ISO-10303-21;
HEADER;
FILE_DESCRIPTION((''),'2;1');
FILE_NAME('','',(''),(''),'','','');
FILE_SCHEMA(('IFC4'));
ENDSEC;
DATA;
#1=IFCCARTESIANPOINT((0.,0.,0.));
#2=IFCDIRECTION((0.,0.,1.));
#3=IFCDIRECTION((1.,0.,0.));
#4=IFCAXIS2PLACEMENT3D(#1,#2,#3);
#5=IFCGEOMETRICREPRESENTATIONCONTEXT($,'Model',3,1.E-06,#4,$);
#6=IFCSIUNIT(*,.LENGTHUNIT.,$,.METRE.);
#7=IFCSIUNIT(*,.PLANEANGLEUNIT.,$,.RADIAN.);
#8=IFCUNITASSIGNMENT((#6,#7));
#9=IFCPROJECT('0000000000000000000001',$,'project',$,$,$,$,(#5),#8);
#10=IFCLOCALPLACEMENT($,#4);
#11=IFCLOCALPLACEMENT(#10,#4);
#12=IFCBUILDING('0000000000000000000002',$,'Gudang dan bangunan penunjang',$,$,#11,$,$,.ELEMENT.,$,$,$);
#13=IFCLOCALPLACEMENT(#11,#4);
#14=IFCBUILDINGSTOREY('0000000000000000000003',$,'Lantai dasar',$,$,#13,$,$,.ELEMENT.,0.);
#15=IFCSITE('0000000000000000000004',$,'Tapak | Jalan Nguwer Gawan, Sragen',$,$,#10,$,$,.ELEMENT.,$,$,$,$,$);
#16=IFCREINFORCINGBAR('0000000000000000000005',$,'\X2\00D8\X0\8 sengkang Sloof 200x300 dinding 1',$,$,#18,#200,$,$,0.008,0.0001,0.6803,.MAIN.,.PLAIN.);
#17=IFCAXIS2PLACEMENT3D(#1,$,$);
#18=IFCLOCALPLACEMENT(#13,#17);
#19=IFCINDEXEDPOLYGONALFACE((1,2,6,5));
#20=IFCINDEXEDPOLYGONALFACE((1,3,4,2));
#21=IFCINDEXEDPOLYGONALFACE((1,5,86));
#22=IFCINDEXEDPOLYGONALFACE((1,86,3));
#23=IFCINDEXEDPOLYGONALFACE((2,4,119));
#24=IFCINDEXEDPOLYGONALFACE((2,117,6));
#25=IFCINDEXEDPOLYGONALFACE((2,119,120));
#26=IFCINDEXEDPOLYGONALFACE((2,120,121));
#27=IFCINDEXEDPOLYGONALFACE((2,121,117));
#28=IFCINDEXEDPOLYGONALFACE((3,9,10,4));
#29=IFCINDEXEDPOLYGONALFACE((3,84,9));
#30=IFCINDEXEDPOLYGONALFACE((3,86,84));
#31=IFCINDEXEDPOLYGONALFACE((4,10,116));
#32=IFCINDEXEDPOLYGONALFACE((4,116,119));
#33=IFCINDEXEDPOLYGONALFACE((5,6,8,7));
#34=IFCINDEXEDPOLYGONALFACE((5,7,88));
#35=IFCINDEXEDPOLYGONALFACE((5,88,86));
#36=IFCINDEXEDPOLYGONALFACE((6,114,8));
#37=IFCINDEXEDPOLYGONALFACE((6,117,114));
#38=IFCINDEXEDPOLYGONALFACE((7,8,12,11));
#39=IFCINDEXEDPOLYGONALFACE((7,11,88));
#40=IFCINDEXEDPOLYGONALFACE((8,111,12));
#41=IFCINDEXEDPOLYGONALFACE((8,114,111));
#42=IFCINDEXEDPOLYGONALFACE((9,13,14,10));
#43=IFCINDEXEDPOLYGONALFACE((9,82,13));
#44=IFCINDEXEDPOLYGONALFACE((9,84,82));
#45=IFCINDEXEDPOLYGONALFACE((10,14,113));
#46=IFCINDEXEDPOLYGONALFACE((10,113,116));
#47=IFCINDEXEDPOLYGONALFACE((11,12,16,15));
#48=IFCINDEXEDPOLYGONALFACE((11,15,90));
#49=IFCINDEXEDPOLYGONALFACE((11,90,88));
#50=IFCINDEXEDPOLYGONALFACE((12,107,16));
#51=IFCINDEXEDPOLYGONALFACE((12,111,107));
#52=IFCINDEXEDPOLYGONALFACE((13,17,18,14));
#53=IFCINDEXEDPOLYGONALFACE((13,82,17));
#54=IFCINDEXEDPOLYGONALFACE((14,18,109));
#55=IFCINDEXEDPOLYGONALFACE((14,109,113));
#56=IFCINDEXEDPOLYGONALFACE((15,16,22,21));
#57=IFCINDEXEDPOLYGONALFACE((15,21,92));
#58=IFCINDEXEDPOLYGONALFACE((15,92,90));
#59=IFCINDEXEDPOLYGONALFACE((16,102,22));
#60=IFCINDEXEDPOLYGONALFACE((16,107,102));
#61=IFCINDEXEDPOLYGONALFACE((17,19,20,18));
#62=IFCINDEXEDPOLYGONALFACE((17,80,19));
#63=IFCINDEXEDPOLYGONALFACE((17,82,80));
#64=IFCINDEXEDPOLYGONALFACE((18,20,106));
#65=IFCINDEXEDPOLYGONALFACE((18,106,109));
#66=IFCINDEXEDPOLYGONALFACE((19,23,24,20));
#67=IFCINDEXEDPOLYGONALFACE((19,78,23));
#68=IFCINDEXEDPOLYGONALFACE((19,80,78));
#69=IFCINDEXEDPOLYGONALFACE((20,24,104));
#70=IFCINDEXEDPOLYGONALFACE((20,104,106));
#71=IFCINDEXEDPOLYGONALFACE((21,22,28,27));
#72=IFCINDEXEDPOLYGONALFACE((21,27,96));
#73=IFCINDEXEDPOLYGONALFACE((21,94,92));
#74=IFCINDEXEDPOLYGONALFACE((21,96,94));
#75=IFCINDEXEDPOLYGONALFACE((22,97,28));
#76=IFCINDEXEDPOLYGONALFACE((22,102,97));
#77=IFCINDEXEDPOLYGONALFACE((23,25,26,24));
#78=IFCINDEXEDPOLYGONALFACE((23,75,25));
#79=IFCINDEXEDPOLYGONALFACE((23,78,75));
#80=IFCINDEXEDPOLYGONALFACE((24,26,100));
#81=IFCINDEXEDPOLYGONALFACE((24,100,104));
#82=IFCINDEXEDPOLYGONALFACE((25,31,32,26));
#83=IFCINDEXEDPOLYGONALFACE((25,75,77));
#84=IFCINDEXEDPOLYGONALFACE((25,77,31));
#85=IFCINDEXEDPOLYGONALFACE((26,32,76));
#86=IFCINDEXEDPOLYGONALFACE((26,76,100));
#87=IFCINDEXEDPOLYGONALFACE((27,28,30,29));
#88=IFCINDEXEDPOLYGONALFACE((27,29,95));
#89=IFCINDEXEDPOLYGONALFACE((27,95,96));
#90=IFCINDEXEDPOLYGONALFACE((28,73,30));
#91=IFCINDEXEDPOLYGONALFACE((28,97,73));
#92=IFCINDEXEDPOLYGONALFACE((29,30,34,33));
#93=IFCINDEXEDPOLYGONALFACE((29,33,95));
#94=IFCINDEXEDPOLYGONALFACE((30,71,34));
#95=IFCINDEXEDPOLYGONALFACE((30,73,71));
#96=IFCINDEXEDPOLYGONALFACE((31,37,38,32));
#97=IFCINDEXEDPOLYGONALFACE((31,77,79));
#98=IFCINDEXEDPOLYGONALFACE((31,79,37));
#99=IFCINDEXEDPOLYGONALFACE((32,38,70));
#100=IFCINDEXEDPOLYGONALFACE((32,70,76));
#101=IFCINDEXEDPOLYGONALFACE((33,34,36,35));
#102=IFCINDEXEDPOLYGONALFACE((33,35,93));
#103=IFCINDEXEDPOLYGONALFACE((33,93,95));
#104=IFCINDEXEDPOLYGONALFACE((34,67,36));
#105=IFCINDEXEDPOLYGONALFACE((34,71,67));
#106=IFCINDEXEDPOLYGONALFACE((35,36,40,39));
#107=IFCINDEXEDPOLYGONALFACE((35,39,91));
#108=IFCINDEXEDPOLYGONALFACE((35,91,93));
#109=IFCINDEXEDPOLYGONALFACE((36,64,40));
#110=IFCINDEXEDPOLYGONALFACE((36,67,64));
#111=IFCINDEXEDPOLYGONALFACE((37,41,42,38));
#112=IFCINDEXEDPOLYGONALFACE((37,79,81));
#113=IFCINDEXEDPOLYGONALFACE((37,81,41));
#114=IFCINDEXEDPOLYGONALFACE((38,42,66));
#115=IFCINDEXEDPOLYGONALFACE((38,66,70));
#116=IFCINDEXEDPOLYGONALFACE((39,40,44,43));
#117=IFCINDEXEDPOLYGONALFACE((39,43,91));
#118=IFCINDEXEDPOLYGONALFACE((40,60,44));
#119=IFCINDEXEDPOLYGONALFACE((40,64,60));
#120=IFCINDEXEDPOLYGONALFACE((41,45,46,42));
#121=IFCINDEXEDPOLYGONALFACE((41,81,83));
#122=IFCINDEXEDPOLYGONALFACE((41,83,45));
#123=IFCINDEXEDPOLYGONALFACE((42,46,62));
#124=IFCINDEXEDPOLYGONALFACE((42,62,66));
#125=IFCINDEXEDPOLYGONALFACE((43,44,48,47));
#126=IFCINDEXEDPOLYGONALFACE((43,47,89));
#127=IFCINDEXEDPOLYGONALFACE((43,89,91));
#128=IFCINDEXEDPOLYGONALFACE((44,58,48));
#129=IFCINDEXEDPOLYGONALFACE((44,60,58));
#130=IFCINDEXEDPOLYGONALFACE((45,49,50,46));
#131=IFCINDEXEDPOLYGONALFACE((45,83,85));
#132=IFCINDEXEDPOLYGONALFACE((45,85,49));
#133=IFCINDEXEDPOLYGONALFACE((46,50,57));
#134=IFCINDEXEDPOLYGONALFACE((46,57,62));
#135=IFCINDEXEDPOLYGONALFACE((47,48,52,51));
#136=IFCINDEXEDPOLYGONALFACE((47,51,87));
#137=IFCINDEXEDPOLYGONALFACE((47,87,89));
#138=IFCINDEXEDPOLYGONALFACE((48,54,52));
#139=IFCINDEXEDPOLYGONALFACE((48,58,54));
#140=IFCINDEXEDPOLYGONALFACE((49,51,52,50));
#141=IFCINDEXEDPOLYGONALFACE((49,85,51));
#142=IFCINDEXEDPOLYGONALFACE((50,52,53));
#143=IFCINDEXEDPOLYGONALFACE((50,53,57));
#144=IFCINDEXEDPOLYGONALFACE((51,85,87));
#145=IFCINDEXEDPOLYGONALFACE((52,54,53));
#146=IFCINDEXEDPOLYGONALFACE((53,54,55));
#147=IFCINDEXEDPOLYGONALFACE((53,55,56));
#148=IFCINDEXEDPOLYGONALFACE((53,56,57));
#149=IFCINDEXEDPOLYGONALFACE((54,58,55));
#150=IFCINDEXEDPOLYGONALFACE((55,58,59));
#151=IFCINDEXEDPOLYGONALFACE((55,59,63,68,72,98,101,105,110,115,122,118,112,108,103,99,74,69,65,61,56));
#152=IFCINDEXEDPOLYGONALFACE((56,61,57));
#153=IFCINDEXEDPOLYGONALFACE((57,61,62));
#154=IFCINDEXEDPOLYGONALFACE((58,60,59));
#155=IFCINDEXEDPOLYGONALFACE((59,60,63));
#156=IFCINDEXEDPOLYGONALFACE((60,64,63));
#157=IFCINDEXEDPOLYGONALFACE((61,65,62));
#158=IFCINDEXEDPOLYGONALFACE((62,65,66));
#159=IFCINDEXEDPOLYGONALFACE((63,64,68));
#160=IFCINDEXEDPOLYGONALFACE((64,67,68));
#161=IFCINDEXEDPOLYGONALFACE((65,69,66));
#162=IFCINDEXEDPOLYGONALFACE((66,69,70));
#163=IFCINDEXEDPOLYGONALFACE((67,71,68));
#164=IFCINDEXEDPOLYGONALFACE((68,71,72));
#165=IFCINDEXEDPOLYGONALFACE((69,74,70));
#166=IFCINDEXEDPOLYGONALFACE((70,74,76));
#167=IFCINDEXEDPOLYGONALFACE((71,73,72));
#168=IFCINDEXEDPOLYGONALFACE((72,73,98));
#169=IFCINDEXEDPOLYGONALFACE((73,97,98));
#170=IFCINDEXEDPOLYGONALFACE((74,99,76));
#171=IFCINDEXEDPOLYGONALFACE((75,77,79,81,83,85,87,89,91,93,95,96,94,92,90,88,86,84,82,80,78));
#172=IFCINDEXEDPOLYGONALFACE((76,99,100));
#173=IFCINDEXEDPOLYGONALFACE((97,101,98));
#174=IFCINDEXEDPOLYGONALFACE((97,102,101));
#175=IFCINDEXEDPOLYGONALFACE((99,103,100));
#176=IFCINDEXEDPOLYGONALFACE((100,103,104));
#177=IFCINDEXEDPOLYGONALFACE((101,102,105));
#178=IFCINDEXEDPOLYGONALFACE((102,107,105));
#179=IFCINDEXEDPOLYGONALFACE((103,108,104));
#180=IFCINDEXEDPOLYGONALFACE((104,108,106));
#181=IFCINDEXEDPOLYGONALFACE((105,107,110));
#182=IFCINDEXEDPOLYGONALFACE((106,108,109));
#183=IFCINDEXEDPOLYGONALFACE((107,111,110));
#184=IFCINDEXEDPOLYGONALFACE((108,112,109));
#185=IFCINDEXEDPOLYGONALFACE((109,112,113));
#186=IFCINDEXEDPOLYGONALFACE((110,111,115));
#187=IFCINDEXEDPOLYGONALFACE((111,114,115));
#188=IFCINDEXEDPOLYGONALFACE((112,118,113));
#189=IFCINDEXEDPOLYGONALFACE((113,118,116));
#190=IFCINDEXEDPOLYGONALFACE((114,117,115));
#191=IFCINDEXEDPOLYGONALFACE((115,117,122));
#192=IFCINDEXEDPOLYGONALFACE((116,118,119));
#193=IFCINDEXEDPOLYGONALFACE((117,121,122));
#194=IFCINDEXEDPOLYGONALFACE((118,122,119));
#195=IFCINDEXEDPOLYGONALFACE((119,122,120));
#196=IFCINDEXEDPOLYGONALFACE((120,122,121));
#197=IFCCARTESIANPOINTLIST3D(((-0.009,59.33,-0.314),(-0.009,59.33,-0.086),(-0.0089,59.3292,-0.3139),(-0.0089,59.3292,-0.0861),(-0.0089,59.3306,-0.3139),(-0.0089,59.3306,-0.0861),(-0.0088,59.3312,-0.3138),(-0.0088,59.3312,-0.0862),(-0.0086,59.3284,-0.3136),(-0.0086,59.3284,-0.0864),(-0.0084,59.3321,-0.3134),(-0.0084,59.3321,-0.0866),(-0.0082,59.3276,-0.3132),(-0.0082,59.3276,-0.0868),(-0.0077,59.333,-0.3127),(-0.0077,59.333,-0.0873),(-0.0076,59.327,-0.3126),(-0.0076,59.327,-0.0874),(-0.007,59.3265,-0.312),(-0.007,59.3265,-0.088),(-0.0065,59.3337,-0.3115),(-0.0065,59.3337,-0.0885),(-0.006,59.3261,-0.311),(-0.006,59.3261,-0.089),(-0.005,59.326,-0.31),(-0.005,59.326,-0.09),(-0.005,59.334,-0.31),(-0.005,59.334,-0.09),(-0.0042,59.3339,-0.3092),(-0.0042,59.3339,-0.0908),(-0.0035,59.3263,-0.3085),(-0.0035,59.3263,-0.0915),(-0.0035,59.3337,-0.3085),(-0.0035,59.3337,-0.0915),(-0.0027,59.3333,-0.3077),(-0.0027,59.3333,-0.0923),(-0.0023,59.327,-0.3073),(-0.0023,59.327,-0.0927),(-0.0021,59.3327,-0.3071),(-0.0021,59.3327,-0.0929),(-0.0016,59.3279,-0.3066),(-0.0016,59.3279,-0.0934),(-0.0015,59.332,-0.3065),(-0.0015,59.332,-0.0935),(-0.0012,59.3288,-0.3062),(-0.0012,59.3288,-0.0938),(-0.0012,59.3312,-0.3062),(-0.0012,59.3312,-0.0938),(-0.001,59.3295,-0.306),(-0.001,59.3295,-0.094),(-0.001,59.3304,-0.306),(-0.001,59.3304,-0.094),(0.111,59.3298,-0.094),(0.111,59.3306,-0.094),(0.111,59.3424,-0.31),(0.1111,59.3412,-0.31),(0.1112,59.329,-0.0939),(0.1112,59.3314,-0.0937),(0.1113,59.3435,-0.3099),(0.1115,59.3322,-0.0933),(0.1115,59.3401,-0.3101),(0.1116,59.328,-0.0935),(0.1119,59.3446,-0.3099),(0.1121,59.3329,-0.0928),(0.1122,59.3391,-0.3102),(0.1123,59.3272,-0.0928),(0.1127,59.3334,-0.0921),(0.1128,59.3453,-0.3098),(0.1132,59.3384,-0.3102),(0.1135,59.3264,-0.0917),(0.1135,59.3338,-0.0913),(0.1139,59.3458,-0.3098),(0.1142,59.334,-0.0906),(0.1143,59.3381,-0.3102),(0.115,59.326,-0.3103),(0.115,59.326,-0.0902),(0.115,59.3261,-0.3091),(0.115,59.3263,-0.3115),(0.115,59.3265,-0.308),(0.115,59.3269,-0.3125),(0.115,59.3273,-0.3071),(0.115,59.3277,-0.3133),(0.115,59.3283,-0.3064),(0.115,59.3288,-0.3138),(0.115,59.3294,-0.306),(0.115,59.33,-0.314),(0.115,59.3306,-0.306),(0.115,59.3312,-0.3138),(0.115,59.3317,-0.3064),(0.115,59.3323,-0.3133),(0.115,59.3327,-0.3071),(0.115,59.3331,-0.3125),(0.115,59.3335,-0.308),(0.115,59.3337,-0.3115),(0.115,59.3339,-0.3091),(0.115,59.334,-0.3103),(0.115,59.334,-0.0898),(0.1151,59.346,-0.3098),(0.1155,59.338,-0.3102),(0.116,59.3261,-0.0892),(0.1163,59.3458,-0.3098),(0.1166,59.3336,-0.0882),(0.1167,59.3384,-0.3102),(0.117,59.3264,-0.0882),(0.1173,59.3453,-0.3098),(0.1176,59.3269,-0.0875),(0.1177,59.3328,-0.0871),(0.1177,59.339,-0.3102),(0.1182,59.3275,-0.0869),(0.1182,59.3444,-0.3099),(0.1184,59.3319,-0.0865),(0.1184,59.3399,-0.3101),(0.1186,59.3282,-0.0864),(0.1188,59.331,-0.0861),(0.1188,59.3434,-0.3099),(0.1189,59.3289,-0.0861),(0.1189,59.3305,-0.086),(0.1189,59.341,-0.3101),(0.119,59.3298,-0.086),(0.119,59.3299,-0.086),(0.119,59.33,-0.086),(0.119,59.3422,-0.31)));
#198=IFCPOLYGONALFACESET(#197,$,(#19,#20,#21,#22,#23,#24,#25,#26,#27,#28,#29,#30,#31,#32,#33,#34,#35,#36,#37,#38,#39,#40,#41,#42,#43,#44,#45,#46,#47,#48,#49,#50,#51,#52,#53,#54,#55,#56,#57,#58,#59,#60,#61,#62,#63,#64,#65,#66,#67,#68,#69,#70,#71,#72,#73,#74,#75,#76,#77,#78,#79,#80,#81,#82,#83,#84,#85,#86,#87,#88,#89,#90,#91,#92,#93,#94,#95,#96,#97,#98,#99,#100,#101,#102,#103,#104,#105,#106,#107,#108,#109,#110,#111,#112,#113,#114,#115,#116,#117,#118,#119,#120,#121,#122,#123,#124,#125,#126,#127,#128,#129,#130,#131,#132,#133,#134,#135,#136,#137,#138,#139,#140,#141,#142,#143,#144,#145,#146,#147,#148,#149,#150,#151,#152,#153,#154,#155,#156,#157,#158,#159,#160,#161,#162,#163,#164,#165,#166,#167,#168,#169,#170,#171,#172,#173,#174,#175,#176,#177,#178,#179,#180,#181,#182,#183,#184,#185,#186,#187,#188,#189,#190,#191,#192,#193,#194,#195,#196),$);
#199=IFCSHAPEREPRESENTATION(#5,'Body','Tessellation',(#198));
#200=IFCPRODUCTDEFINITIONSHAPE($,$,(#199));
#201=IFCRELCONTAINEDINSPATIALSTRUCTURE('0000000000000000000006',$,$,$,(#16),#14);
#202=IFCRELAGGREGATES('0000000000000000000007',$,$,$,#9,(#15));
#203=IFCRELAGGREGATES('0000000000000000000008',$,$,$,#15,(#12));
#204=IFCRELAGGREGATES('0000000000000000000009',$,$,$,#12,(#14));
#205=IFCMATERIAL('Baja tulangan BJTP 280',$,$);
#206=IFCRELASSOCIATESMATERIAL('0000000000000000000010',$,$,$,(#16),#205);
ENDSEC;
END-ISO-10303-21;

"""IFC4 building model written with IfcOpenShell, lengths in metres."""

from ifc_helpers import new_model, entity, si_unit, origin_with_axes, place, context, project, spatial, material, element, save


model = new_model("IFC4")

# Units and contexts
model_context = context("Model", 3, precision=1e-06, world=origin_with_axes())
ifc_project = project(units=[si_unit("LENGTHUNIT", "METRE"), si_unit("PLANEANGLEUNIT", "RADIAN")], contexts=[model_context])

# Site, building, storey
site_placement = place(None, origin_with_axes())
site = spatial("IfcSite", under=ifc_project, at=site_placement, Name="Tapak | Jalan Nguwer Gawan, Sragen", CompositionType="ELEMENT")
building_placement = place(site_placement, origin_with_axes())
building = spatial("IfcBuilding", under=site, at=building_placement, Name="Gudang dan bangunan penunjang", CompositionType="ELEMENT")
storey_placement = place(building_placement, origin_with_axes())
storey = spatial("IfcBuildingStorey", under=building, at=storey_placement, Name="Lantai dasar", CompositionType="ELEMENT", Elevation=0.0)

# Shared definitions
placement = place(None, origin_with_axes())

# Reinforcing bar
ifc_material_1 = material(Name="Baja tulangan BJTP 280")
element("IfcReinforcingBar", 1, at=placement, inside=storey, material=ifc_material_1, Name="Ø8 sengkang Sloof 200x300 dinding 1", BarLength=0.6803, BarSurface="PLAIN", CrossSectionArea=0.0001, NominalDiameter=0.008, PredefinedType="MAIN", context=model_context, shape_type="AdvancedSweptSolid", body=[
    entity("IfcSweptDiskSolid", entity("IfcPolyline", [entity("IfcCartesianPoint", [0.115, 59.33, -0.31]), entity("IfcCartesianPoint", [-0.005, 59.33, -0.31]), entity("IfcCartesianPoint", [-0.005, 59.33, -0.09]), entity("IfcCartesianPoint", [0.115, 59.33, -0.09]), entity("IfcCartesianPoint", [0.115, 59.342, -0.31])]), 0.004),
])

save(model, "model.ifc")
